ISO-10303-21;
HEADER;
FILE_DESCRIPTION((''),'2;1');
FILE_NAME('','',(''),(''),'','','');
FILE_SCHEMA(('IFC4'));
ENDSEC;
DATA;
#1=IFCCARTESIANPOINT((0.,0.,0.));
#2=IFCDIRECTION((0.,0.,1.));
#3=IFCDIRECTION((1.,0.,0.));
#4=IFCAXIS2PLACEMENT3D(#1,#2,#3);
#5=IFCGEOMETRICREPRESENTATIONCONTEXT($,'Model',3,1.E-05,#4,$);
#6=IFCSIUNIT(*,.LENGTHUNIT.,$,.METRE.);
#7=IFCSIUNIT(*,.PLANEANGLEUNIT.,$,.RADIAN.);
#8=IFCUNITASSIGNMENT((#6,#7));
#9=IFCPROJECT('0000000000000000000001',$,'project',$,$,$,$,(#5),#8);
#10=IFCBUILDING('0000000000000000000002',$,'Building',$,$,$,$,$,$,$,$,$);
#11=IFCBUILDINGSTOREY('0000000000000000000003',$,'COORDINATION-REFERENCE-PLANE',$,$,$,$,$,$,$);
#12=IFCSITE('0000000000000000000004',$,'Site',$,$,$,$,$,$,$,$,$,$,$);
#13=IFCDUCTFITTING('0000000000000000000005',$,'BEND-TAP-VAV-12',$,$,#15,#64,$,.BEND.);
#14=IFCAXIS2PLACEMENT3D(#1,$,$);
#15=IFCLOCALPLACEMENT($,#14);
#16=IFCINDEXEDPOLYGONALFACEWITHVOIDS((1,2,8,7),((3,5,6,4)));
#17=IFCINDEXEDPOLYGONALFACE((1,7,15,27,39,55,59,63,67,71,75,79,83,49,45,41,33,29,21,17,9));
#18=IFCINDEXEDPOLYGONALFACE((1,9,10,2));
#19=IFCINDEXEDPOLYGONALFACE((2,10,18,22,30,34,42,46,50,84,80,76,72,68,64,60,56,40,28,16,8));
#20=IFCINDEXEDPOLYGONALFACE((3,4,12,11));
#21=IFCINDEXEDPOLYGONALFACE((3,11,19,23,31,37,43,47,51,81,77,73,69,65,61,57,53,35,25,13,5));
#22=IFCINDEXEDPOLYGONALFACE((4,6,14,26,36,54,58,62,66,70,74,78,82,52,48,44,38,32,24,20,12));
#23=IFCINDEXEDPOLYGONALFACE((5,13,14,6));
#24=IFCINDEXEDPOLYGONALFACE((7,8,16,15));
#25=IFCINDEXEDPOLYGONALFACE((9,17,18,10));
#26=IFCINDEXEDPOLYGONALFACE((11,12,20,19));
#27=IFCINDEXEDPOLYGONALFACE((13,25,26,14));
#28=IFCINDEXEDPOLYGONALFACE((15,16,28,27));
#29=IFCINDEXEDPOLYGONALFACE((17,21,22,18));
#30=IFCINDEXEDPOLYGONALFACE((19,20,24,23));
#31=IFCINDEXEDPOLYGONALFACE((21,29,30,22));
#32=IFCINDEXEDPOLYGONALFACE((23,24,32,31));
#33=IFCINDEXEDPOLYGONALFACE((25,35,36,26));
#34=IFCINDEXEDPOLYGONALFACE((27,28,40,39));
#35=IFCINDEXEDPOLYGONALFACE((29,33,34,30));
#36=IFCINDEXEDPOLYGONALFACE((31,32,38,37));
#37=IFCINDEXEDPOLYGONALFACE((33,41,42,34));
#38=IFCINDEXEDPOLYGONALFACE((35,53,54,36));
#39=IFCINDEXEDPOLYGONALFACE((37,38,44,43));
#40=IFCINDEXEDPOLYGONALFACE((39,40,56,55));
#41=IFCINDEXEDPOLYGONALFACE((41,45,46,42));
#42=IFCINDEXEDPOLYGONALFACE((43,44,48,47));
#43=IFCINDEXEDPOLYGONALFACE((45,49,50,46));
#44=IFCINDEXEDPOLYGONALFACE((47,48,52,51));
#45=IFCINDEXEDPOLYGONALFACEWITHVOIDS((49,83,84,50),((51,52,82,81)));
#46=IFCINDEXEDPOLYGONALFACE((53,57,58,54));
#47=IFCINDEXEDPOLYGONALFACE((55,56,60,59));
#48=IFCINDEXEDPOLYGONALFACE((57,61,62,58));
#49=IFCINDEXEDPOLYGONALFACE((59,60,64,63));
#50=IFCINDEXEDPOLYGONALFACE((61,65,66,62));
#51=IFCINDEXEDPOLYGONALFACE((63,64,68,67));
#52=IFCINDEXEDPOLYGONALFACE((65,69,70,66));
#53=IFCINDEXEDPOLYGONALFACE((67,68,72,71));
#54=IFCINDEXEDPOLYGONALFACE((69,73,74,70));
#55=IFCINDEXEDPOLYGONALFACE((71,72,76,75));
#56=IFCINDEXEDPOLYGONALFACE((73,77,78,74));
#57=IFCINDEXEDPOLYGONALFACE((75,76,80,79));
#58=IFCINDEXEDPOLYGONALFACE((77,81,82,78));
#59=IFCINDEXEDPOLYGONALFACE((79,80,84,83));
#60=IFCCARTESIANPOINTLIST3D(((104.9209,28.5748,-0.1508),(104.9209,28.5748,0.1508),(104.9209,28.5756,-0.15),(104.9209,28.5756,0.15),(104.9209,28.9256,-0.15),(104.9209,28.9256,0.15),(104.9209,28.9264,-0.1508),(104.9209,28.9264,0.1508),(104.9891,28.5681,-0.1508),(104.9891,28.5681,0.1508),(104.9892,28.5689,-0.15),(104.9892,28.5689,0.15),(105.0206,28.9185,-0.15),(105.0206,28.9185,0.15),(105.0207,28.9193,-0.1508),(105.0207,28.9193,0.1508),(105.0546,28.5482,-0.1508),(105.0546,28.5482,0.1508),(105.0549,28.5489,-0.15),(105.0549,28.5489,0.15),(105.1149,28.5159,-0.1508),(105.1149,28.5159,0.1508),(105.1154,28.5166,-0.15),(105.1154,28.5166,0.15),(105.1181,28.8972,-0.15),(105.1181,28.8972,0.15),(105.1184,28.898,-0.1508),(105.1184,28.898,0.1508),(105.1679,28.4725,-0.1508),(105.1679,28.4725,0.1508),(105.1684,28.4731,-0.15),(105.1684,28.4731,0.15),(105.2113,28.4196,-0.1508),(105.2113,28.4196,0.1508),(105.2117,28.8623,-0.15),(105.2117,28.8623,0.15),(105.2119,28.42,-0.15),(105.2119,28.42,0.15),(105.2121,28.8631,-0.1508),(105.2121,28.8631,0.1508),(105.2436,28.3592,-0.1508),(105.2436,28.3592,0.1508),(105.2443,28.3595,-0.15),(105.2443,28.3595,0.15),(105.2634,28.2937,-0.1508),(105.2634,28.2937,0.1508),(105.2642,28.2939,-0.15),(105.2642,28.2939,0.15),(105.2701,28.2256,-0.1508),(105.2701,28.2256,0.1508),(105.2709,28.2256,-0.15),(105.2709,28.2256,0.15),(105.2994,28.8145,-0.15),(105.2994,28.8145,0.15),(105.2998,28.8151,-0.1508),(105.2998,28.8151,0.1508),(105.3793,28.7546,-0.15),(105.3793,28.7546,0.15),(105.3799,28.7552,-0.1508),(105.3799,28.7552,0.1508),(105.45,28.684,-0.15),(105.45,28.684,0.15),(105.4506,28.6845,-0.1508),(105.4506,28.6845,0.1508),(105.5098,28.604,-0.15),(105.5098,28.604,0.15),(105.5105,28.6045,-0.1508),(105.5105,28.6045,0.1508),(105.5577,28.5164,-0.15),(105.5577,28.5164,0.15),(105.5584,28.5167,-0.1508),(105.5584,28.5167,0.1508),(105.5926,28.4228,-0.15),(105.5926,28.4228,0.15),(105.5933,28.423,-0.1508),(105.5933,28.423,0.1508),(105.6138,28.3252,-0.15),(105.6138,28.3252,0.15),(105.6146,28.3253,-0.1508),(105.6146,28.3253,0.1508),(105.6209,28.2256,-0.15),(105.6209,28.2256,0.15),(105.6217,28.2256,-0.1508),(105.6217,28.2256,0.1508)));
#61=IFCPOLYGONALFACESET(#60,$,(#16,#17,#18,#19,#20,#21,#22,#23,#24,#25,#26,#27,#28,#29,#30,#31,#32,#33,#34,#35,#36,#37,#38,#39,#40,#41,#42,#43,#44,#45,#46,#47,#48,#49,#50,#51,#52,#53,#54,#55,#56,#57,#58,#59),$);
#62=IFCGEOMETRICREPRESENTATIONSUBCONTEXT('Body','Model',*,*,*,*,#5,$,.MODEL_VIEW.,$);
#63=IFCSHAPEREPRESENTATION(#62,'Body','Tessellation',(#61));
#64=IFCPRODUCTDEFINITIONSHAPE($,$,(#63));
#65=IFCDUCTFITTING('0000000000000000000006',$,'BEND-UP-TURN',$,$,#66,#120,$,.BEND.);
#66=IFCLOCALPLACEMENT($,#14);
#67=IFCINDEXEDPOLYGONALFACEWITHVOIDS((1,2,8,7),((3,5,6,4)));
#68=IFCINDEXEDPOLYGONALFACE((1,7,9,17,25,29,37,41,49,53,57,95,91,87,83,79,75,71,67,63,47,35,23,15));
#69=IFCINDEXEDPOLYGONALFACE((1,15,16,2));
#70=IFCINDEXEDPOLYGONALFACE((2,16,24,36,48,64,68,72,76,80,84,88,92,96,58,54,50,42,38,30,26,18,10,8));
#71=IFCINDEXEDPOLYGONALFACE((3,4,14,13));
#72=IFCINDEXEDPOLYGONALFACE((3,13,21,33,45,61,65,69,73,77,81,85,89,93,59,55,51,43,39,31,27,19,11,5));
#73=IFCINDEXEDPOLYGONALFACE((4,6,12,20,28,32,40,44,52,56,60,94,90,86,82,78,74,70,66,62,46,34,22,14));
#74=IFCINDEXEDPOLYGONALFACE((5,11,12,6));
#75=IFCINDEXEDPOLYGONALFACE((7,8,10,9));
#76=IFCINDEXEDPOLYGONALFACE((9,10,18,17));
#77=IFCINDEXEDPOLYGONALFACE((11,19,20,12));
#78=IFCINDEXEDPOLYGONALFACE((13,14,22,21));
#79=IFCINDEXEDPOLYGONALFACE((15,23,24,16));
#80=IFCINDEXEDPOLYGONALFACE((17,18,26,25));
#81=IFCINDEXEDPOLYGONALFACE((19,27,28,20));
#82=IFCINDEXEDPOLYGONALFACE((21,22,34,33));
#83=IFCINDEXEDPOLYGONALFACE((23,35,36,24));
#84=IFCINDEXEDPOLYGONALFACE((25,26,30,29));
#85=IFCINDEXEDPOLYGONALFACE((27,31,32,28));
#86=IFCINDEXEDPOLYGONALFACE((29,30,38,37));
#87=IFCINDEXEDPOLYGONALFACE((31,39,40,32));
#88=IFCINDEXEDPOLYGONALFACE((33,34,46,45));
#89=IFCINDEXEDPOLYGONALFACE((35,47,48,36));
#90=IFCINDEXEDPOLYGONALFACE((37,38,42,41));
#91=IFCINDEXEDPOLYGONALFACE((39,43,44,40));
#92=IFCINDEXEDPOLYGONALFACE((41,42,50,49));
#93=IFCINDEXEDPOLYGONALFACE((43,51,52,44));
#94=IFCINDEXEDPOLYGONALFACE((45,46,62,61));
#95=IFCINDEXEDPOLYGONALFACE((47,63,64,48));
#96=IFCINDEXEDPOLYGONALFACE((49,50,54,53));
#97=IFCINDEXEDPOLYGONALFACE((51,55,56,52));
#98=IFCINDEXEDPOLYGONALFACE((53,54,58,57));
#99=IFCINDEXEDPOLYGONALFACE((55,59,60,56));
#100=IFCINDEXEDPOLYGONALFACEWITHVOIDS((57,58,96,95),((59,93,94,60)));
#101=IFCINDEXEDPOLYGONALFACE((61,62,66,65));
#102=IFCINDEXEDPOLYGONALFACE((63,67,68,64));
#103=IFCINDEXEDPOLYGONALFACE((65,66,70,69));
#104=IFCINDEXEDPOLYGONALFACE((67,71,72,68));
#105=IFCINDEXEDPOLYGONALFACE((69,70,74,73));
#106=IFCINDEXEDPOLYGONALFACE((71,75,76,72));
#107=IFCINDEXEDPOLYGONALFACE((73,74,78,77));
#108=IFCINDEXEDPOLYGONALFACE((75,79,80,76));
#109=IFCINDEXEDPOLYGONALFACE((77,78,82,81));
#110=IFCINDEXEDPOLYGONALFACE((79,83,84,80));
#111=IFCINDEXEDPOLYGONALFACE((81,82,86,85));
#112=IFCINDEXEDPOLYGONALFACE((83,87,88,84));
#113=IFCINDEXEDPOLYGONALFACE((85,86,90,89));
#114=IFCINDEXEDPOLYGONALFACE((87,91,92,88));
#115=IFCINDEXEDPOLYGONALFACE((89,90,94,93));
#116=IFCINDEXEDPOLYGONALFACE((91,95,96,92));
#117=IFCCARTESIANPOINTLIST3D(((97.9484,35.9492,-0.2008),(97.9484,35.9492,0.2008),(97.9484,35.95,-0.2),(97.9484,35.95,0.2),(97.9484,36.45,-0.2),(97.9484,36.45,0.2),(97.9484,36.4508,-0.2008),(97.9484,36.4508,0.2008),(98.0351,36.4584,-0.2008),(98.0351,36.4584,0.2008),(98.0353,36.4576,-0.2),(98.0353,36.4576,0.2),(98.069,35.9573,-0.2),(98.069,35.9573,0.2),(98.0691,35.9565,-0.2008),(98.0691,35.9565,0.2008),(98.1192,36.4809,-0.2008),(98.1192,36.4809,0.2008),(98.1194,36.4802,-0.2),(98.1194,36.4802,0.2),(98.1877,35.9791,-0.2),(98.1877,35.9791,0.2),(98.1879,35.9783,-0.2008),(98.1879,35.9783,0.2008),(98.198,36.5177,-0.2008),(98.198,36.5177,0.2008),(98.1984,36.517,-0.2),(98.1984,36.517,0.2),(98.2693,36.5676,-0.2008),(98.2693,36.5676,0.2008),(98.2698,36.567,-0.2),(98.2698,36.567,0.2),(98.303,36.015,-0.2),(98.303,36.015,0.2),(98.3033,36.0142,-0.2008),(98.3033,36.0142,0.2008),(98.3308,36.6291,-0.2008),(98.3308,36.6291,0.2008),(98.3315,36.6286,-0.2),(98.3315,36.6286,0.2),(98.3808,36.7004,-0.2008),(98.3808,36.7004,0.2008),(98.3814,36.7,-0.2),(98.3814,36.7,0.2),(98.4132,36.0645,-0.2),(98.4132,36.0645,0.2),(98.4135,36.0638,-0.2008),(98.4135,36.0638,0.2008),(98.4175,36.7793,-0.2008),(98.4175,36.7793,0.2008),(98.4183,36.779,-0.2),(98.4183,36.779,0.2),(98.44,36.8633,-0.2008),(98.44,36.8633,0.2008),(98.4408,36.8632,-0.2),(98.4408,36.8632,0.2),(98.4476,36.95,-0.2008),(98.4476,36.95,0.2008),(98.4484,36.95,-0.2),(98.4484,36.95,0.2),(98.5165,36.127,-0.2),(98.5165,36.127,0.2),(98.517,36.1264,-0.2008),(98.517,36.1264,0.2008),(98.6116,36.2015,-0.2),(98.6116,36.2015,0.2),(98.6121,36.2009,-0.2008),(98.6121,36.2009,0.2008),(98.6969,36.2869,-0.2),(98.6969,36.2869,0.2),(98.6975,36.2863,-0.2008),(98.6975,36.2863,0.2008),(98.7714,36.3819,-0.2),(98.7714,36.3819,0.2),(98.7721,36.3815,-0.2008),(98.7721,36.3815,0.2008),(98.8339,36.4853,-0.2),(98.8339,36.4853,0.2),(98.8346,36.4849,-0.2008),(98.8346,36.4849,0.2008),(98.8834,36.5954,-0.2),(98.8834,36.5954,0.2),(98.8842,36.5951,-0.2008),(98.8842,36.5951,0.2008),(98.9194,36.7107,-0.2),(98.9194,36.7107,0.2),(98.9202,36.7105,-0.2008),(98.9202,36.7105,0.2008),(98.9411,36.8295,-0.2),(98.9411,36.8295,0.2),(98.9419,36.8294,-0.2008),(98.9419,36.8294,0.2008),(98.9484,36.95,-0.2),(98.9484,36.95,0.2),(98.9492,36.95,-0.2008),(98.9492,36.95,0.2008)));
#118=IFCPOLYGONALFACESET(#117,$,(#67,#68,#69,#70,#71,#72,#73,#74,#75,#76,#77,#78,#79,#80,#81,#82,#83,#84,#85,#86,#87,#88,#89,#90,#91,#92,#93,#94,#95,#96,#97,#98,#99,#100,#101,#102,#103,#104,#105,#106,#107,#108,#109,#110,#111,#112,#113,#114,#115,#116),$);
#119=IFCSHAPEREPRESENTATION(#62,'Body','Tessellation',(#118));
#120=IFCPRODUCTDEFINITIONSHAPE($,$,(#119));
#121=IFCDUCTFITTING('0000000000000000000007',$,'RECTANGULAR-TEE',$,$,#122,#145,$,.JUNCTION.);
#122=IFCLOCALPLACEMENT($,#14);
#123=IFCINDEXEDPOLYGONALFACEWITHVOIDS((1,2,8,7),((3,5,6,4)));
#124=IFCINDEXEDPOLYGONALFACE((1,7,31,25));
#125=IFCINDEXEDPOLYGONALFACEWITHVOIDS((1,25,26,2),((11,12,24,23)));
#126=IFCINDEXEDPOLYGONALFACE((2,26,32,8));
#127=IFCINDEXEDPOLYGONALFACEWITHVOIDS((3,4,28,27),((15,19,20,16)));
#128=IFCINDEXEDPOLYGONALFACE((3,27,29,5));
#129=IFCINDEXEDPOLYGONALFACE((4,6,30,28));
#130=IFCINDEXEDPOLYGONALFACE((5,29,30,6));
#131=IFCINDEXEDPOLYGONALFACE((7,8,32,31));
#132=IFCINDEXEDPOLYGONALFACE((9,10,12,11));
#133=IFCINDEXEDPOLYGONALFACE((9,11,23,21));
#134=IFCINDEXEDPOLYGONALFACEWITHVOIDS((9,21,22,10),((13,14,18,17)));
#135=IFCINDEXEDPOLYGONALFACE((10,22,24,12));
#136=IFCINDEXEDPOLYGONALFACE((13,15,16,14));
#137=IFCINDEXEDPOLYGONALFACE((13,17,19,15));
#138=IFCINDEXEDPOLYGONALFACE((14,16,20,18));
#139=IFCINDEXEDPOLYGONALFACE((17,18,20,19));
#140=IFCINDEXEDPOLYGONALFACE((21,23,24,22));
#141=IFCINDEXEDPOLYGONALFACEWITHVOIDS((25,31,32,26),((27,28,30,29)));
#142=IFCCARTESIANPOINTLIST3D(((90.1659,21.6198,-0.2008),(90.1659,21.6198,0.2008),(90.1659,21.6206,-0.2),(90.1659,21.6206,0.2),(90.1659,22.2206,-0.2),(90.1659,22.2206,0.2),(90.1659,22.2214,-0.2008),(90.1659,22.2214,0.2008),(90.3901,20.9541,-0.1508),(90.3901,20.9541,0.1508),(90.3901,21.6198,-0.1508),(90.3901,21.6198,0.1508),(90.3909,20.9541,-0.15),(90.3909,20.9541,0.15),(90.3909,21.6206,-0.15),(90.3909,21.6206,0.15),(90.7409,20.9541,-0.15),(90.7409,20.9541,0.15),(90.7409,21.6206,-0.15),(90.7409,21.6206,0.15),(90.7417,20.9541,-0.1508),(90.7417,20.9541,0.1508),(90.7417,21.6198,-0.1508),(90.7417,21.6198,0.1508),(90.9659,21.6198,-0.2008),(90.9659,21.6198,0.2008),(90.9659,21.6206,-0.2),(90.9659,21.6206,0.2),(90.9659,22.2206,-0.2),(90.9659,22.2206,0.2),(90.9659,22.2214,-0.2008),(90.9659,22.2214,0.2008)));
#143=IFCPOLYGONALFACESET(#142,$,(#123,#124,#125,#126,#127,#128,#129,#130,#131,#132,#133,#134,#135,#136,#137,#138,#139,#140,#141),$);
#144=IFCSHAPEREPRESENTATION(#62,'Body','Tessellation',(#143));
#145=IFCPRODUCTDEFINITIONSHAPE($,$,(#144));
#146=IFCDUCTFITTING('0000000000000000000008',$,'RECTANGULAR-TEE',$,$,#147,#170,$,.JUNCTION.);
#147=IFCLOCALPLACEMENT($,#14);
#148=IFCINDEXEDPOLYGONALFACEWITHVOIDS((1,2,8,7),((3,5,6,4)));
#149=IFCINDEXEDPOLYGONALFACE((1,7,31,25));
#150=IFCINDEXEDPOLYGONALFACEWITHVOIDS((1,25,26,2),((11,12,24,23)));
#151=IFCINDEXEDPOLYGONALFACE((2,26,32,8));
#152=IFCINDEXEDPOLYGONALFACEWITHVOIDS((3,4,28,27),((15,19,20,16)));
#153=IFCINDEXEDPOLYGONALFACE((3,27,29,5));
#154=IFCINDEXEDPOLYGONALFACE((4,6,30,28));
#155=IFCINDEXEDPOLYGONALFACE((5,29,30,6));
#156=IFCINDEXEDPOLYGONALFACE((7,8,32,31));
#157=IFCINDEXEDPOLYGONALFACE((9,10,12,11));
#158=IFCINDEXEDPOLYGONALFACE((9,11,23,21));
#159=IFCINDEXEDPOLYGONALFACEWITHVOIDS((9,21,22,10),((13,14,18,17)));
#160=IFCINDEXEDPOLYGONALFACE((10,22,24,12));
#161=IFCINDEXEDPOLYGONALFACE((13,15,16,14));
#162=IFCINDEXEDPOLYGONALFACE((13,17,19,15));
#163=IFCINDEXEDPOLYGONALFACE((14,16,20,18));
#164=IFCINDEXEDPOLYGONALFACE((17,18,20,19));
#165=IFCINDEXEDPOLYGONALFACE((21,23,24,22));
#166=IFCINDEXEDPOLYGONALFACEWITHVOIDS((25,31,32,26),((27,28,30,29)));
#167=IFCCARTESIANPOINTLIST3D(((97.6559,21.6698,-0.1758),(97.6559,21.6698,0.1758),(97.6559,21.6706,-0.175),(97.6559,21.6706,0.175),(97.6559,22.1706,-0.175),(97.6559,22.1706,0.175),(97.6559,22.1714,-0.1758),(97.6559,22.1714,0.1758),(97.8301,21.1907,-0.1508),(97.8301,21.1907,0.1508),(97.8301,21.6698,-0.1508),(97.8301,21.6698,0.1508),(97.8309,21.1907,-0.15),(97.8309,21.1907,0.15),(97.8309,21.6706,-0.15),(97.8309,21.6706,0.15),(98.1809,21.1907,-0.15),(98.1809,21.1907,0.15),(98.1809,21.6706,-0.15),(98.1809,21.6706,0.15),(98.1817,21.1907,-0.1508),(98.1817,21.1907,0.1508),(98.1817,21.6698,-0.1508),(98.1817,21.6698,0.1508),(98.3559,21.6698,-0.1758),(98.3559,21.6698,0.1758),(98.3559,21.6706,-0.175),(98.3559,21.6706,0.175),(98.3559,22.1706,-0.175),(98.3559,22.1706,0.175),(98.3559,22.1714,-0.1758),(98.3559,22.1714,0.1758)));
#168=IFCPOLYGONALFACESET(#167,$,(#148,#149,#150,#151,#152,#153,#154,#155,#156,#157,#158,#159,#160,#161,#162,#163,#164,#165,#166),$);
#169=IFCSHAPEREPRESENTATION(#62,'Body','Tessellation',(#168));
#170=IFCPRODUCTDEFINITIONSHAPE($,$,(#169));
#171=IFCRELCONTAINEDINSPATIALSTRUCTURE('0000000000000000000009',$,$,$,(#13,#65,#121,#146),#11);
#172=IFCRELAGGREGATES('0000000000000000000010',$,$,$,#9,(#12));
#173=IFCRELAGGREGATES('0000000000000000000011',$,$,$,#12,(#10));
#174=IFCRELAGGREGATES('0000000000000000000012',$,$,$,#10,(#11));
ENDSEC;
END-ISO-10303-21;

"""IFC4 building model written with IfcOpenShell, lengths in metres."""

from ifc_helpers import new_model, entity, si_unit, frame, origin_with_axes, place, context, subcontext, project, spatial, rectangle, extrude, boolean, element, save


model = new_model("IFC4")

# Units and contexts
model_context = context("Model", 3, precision=1e-05, world=origin_with_axes())
body_context = subcontext(model_context, "Body", "Model", "MODEL_VIEW")
ifc_project = project(units=[si_unit("LENGTHUNIT", "METRE"), si_unit("PLANEANGLEUNIT", "RADIAN")], contexts=[model_context])

# Site, building, storey
site = spatial("IfcSite", under=ifc_project, Name="Site")
building = spatial("IfcBuilding", under=site, Name="Building")
storey = spatial("IfcBuildingStorey", under=building, Name="COORDINATION-REFERENCE-PLANE")

# Duct fittings
duct_fitting_1_placement = place(None, frame((104.9209, 28.2256, 0.0), z_axis=(0.0, 0.0, -1.0), x_axis=(0.0, 1.0, 0.0)))
cartesian_point_1 = entity("IfcCartesianPoint", [0.0, 0.0, 0.0])
element("IfcDuctFitting", 1, at=duct_fitting_1_placement, inside=storey, Name="BEND-TAP-VAV-12", PredefinedType="BEND", context=body_context, shape_type="SweptSolid", body=[
    entity("IfcRevolvedAreaSolid", entity("IfcRectangleHollowProfileDef", "AREA", None, entity("IfcAxis2Placement2D", entity("IfcCartesianPoint", [0.525, 0.0])), 0.3516, 0.3016, 0.0008), entity("IfcAxis2Placement3D", cartesian_point_1, entity("IfcDirection", [0.0, -1.0, 0.0]), entity("IfcDirection", [1.0, 0.0, 0.0])), entity("IfcAxis1Placement", cartesian_point_1, entity("IfcDirection", [0.0, 1.0, 0.0])), 1.570796),
])
duct_fitting_2_placement = place(None, frame((97.9484, 36.95, 0.0), z_axis=(0.0, 0.0, 1.0), x_axis=(0.0, -1.0, 0.0)))
cartesian_point_2 = entity("IfcCartesianPoint", [0.0, 0.0, 0.0])
element("IfcDuctFitting", 2, at=duct_fitting_2_placement, inside=storey, Name="BEND-UP-TURN", PredefinedType="BEND", context=body_context, shape_type="SweptSolid", body=[
    entity("IfcRevolvedAreaSolid", entity("IfcRectangleHollowProfileDef", "AREA", None, entity("IfcAxis2Placement2D", entity("IfcCartesianPoint", [0.75, 0.0])), 0.5016, 0.4016, 0.0008), entity("IfcAxis2Placement3D", cartesian_point_2, entity("IfcDirection", [0.0, -1.0, 0.0]), entity("IfcDirection", [1.0, 0.0, 0.0])), entity("IfcAxis1Placement", cartesian_point_2, entity("IfcDirection", [0.0, 1.0, 0.0])), 1.570796),
])
duct_fitting_3_placement = place(None, frame((90.5659, 21.9206, 0.0), z_axis=(1.0, 0.0, 0.0), x_axis=(0.0, -1.0, 0.0)))
solid_1 = boolean("UNION", extrude(rectangle(XDim=0.6, YDim=0.4), frame((0.0, 0.0, -0.4), z_axis=(0.0, 0.0, 1.0), x_axis=(1.0, 0.0, 0.0)), (0.0, 0.0, 1.0), 0.8), extrude(rectangle(XDim=0.35, YDim=0.3), frame((0.0, 0.0, 0.0), z_axis=(1.0, 0.0, 0.0), x_axis=(0.0, 0.0, -1.0)), (0.0, 0.0, 1.0), 0.9665))
element("IfcDuctFitting", 3, at=duct_fitting_3_placement, inside=storey, Name="RECTANGULAR-TEE", PredefinedType="JUNCTION", context=body_context, shape_type="CSG", body=[
    boolean("DIFFERENCE", boolean("UNION", extrude(rectangle(XDim=0.6016, YDim=0.4016), frame((0.0, 0.0, -0.4), z_axis=(0.0, 0.0, 1.0), x_axis=(1.0, 0.0, 0.0)), (0.0, 0.0, 1.0), 0.8), extrude(rectangle(XDim=0.3516, YDim=0.3016), frame((0.0, 0.0, 0.0), z_axis=(1.0, 0.0, 0.0), x_axis=(0.0, 0.0, -1.0)), (0.0, 0.0, 1.0), 0.9665)), solid_1),
])
duct_fitting_4_placement = place(None, frame((98.0059, 21.9206, 0.0), z_axis=(1.0, 0.0, 0.0), x_axis=(0.0, -1.0, 0.0)))
solid_2 = boolean("UNION", extrude(rectangle(XDim=0.5, YDim=0.35), frame((0.0, 0.0, -0.35), z_axis=(0.0, 0.0, 1.0), x_axis=(1.0, 0.0, 0.0)), (0.0, 0.0, 1.0), 0.7), extrude(rectangle(XDim=0.35, YDim=0.3), frame((0.0, 0.0, 0.0), z_axis=(1.0, 0.0, 0.0), x_axis=(0.0, 0.0, -1.0)), (0.0, 0.0, 1.0), 0.7299))
element("IfcDuctFitting", 4, at=duct_fitting_4_placement, inside=storey, Name="RECTANGULAR-TEE", PredefinedType="JUNCTION", context=body_context, shape_type="CSG", body=[
    boolean("DIFFERENCE", boolean("UNION", extrude(rectangle(XDim=0.5016, YDim=0.3516), frame((0.0, 0.0, -0.35), z_axis=(0.0, 0.0, 1.0), x_axis=(1.0, 0.0, 0.0)), (0.0, 0.0, 1.0), 0.7), extrude(rectangle(XDim=0.3516, YDim=0.3016), frame((0.0, 0.0, 0.0), z_axis=(1.0, 0.0, 0.0), x_axis=(0.0, 0.0, -1.0)), (0.0, 0.0, 1.0), 0.7299)), solid_2),
])

save(model, "model.ifc")
